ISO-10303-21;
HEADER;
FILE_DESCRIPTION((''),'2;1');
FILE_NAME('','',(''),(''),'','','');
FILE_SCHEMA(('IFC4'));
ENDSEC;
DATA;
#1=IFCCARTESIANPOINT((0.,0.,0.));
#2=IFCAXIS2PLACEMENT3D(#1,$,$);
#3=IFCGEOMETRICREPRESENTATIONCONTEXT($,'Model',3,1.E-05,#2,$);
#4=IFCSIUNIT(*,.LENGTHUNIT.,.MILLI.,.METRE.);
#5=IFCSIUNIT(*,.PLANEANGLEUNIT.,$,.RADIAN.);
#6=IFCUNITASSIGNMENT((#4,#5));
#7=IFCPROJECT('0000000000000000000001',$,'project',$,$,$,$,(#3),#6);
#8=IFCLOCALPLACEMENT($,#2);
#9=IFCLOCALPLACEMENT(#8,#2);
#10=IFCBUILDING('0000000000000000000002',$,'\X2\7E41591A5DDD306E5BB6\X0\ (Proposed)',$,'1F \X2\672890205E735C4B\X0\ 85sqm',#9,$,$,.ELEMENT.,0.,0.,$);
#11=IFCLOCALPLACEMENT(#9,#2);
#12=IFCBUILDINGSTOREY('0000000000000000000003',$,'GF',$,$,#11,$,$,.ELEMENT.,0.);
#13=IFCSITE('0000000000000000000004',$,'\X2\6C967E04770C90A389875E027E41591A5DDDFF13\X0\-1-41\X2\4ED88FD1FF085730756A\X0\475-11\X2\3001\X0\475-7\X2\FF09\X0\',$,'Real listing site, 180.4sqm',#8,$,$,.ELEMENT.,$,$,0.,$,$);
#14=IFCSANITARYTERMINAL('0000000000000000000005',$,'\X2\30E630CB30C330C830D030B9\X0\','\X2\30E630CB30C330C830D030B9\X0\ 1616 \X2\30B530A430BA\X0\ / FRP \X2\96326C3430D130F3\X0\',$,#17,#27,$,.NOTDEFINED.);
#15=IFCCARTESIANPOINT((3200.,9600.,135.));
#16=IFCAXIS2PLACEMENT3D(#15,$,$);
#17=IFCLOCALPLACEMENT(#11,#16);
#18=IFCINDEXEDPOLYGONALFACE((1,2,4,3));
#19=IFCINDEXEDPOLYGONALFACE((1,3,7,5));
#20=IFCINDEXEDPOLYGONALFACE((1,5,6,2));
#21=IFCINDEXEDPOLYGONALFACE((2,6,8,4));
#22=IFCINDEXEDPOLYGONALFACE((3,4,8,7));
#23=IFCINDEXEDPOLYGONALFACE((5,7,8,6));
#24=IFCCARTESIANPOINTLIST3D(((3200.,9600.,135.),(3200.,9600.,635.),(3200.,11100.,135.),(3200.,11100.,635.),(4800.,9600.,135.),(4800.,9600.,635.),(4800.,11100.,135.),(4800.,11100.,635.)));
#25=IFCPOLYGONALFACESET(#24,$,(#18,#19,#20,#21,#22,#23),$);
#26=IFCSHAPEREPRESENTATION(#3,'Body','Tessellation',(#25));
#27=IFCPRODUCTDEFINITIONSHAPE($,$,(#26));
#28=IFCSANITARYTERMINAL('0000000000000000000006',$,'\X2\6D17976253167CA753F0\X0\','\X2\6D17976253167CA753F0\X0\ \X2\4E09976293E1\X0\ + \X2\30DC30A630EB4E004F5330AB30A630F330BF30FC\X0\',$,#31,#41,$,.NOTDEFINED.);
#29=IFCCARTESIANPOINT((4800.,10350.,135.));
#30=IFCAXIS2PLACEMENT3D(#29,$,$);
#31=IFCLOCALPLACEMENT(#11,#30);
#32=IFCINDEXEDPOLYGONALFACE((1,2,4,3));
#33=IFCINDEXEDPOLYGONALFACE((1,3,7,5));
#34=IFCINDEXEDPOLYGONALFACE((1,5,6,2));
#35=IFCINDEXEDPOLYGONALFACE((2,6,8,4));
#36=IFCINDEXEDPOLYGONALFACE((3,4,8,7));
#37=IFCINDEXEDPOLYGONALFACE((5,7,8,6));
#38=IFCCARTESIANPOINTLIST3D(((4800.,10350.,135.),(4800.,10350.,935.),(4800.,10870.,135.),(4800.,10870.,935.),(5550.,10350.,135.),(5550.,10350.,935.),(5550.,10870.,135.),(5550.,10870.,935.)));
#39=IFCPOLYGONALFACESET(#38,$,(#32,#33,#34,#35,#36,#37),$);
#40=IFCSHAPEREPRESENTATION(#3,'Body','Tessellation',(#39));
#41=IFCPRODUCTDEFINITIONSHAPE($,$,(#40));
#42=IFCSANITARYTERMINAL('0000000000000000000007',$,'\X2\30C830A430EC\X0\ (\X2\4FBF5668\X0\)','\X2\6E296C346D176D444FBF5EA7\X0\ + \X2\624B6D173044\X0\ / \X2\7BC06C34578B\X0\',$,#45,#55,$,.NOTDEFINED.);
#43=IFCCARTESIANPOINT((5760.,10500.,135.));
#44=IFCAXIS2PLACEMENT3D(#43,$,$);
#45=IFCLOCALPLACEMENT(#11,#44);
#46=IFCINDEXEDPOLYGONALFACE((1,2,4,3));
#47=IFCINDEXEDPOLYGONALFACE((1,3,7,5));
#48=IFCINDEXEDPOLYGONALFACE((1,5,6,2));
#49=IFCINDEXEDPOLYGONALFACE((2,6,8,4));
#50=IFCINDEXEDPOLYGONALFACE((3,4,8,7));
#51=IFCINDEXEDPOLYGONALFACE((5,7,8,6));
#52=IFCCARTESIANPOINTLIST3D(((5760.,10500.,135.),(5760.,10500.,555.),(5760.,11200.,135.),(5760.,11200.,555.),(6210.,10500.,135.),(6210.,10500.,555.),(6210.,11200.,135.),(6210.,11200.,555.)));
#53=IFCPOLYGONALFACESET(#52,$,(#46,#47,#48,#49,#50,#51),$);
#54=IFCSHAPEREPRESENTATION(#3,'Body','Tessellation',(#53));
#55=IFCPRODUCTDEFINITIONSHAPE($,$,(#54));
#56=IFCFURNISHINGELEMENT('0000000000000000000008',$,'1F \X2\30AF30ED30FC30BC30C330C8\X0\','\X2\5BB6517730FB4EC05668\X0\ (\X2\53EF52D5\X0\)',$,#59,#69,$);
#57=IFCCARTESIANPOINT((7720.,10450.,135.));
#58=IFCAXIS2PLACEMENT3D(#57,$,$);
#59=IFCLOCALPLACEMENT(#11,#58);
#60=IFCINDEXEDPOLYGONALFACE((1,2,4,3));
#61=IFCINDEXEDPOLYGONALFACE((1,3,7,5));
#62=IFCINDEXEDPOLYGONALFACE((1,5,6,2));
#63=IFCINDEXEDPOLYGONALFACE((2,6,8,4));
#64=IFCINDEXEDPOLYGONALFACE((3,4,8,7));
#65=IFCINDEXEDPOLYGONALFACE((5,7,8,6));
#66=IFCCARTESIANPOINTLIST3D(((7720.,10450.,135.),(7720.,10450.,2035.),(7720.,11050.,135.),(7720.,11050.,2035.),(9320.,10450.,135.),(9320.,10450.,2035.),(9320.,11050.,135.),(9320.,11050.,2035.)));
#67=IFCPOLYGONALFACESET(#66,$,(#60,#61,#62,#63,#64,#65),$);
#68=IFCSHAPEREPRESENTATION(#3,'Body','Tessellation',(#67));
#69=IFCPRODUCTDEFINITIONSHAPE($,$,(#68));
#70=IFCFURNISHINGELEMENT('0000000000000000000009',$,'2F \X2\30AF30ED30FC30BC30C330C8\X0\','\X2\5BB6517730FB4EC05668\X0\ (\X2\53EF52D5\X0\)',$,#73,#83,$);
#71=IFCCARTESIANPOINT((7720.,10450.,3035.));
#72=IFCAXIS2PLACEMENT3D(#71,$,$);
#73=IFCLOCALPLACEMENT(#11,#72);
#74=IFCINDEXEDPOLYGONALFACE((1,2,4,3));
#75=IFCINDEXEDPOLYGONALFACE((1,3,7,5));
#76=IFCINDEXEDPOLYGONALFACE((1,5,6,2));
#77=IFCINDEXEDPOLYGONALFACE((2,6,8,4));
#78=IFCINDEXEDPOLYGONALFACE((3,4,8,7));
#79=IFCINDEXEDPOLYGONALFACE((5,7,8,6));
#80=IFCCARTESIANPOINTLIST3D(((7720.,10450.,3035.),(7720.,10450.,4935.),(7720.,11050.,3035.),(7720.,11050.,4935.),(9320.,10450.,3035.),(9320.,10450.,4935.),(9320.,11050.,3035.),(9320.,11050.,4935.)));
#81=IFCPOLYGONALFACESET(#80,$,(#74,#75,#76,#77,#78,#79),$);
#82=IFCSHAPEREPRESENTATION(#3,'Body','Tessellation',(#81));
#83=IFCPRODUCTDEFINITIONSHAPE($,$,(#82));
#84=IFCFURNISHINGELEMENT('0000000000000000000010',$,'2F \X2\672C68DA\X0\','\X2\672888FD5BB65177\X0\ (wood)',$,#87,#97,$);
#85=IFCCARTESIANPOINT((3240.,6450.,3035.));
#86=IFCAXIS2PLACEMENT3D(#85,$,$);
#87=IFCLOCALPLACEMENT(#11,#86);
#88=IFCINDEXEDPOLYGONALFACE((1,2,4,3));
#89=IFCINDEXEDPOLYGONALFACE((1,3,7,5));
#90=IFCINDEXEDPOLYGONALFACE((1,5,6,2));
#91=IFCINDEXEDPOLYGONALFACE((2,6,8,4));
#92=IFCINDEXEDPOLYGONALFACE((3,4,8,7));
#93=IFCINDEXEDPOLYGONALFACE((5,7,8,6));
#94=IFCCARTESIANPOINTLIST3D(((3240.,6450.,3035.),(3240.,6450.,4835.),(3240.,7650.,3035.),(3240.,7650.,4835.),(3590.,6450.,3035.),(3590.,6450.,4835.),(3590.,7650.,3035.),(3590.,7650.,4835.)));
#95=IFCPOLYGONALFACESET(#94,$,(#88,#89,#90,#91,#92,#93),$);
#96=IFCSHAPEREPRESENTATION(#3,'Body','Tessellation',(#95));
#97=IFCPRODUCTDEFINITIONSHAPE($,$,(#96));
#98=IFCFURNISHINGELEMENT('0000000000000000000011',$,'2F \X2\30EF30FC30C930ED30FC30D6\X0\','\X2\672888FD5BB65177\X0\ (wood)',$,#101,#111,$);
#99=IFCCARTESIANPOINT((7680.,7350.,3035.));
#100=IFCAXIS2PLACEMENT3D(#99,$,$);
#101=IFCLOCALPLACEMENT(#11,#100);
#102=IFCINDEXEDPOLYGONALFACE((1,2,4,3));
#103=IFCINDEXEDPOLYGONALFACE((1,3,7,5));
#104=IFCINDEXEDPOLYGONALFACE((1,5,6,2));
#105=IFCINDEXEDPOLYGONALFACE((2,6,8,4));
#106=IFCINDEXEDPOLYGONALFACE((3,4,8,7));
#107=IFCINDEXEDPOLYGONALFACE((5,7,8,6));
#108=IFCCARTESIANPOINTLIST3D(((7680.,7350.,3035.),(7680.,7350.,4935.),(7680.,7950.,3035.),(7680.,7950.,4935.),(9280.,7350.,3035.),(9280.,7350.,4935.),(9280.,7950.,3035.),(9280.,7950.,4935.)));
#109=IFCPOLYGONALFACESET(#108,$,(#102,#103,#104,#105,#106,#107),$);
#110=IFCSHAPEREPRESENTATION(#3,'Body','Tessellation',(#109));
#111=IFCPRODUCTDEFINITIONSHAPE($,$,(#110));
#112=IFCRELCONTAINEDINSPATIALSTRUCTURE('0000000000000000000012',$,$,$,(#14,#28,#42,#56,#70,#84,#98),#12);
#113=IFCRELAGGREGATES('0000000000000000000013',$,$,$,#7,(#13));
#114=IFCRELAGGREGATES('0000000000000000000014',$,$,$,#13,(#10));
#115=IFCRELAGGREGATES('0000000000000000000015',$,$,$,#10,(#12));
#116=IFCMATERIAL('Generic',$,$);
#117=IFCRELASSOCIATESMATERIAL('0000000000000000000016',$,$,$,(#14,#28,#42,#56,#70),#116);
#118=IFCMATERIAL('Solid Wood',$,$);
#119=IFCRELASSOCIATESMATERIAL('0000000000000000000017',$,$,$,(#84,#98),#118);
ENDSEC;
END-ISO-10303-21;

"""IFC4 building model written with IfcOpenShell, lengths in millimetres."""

from ifc_helpers import new_model, si_unit, frame, frame_2d, origin, place, context, project, spatial, rectangle, extrude, material, element, save


model = new_model("IFC4")

# Units and contexts
model_context = context("Model", 3, precision=1e-05, world=origin())
ifc_project = project(units=[si_unit("LENGTHUNIT", "METRE", prefix="MILLI"), si_unit("PLANEANGLEUNIT", "RADIAN")], contexts=[model_context])

# Site, building, storey
site_placement = place(None, origin())
site = spatial("IfcSite", under=ifc_project, at=site_placement, Name="沖縄県那覇市繁多川３-1-41付近（地番475-11、475-7）", ObjectType="Real listing site, 180.4sqm", CompositionType="ELEMENT", RefElevation=0.0)
building_placement = place(site_placement, origin())
building = spatial("IfcBuilding", under=site, at=building_placement, Name="繁多川の家 (Proposed)", ObjectType="1F 木造平屋 85sqm", CompositionType="ELEMENT", ElevationOfRefHeight=0.0, ElevationOfTerrain=0.0)
storey_placement = place(building_placement, origin())
storey = spatial("IfcBuildingStorey", under=building, at=storey_placement, Name="GF", CompositionType="ELEMENT", Elevation=0.0)

# Shared definitions
ifc_material_1 = material(Name="Solid Wood")

# Shared definitions
ifc_material_2 = material(Name="Generic")

# Sanitary terminals
sanitary_terminal_1_placement = place(storey_placement, frame((3200.0, 9600.0, 135.0)))
element("IfcSanitaryTerminal", 1, at=sanitary_terminal_1_placement, inside=storey, material=ifc_material_2, Name="ユニットバス", Description="ユニットバス 1616 サイズ / FRP 防水パン", PredefinedType="NOTDEFINED", context=model_context, shape_type="SweptSolid", body=[
    extrude(rectangle(XDim=1600.0, YDim=1500.0, at=frame_2d((800.0, 750.0))), frame((3200.0, 9600.0, 135.0)), (0.0, 0.0, 1.0), 500.0),
])
sanitary_terminal_2_placement = place(storey_placement, frame((4800.0, 10350.0, 135.0)))
element("IfcSanitaryTerminal", 2, at=sanitary_terminal_2_placement, inside=storey, material=ifc_material_2, Name="洗面化粧台", Description="洗面化粧台 三面鏡 + ボウル一体カウンター", PredefinedType="NOTDEFINED", context=model_context, shape_type="SweptSolid", body=[
    extrude(rectangle(XDim=750.0, YDim=520.0, at=frame_2d((375.0, 260.0))), frame((4800.0, 10350.0, 135.0)), (0.0, 0.0, 1.0), 800.0),
])
sanitary_terminal_3_placement = place(storey_placement, frame((5760.0, 10500.0, 135.0)))
element("IfcSanitaryTerminal", 3, at=sanitary_terminal_3_placement, inside=storey, material=ifc_material_2, Name="トイレ (便器)", Description="温水洗浄便座 + 手洗い / 節水型", PredefinedType="NOTDEFINED", context=model_context, shape_type="SweptSolid", body=[
    extrude(rectangle(XDim=450.0, YDim=700.0, at=frame_2d((225.0, 350.0))), frame((5760.0, 10500.0, 135.0)), (0.0, 0.0, 1.0), 420.0),
])

# Furnishing elements
furnishing_1_placement = place(storey_placement, frame((7720.0, 10450.0, 135.0)))
element("IfcFurnishingElement", 4, at=furnishing_1_placement, inside=storey, material=ifc_material_2, Name="1F クローゼット", Description="家具・什器 (可動)", context=model_context, shape_type="SweptSolid", body=[
    extrude(rectangle(XDim=1600.0, YDim=600.0, at=frame_2d((800.0, 300.0))), frame((7720.0, 10450.0, 135.0)), (0.0, 0.0, 1.0), 1900.0),
])
furnishing_2_placement = place(storey_placement, frame((7720.0, 10450.0, 3035.0)))
element("IfcFurnishingElement", 5, at=furnishing_2_placement, inside=storey, material=ifc_material_2, Name="2F クローゼット", Description="家具・什器 (可動)", context=model_context, shape_type="SweptSolid", body=[
    extrude(rectangle(XDim=1600.0, YDim=600.0, at=frame_2d((800.0, 300.0))), frame((7720.0, 10450.0, 3035.0)), (0.0, 0.0, 1.0), 1900.0),
])
furnishing_3_placement = place(storey_placement, frame((3240.0, 6450.0, 3035.0)))
element("IfcFurnishingElement", 6, at=furnishing_3_placement, inside=storey, material=ifc_material_1, Name="2F 本棚", Description="木製家具 (wood)", context=model_context, shape_type="SweptSolid", body=[
    extrude(rectangle(XDim=350.0, YDim=1200.0, at=frame_2d((175.0, 600.0))), frame((3240.0, 6450.0, 3035.0)), (0.0, 0.0, 1.0), 1800.0),
])
furnishing_4_placement = place(storey_placement, frame((7680.0, 7350.0, 3035.0)))
element("IfcFurnishingElement", 7, at=furnishing_4_placement, inside=storey, material=ifc_material_1, Name="2F ワードローブ", Description="木製家具 (wood)", context=model_context, shape_type="SweptSolid", body=[
    extrude(rectangle(XDim=1600.0, YDim=600.0, at=frame_2d((800.0, 300.0))), frame((7680.0, 7350.0, 3035.0)), (0.0, 0.0, 1.0), 1900.0),
])

save(model, "model.ifc")
